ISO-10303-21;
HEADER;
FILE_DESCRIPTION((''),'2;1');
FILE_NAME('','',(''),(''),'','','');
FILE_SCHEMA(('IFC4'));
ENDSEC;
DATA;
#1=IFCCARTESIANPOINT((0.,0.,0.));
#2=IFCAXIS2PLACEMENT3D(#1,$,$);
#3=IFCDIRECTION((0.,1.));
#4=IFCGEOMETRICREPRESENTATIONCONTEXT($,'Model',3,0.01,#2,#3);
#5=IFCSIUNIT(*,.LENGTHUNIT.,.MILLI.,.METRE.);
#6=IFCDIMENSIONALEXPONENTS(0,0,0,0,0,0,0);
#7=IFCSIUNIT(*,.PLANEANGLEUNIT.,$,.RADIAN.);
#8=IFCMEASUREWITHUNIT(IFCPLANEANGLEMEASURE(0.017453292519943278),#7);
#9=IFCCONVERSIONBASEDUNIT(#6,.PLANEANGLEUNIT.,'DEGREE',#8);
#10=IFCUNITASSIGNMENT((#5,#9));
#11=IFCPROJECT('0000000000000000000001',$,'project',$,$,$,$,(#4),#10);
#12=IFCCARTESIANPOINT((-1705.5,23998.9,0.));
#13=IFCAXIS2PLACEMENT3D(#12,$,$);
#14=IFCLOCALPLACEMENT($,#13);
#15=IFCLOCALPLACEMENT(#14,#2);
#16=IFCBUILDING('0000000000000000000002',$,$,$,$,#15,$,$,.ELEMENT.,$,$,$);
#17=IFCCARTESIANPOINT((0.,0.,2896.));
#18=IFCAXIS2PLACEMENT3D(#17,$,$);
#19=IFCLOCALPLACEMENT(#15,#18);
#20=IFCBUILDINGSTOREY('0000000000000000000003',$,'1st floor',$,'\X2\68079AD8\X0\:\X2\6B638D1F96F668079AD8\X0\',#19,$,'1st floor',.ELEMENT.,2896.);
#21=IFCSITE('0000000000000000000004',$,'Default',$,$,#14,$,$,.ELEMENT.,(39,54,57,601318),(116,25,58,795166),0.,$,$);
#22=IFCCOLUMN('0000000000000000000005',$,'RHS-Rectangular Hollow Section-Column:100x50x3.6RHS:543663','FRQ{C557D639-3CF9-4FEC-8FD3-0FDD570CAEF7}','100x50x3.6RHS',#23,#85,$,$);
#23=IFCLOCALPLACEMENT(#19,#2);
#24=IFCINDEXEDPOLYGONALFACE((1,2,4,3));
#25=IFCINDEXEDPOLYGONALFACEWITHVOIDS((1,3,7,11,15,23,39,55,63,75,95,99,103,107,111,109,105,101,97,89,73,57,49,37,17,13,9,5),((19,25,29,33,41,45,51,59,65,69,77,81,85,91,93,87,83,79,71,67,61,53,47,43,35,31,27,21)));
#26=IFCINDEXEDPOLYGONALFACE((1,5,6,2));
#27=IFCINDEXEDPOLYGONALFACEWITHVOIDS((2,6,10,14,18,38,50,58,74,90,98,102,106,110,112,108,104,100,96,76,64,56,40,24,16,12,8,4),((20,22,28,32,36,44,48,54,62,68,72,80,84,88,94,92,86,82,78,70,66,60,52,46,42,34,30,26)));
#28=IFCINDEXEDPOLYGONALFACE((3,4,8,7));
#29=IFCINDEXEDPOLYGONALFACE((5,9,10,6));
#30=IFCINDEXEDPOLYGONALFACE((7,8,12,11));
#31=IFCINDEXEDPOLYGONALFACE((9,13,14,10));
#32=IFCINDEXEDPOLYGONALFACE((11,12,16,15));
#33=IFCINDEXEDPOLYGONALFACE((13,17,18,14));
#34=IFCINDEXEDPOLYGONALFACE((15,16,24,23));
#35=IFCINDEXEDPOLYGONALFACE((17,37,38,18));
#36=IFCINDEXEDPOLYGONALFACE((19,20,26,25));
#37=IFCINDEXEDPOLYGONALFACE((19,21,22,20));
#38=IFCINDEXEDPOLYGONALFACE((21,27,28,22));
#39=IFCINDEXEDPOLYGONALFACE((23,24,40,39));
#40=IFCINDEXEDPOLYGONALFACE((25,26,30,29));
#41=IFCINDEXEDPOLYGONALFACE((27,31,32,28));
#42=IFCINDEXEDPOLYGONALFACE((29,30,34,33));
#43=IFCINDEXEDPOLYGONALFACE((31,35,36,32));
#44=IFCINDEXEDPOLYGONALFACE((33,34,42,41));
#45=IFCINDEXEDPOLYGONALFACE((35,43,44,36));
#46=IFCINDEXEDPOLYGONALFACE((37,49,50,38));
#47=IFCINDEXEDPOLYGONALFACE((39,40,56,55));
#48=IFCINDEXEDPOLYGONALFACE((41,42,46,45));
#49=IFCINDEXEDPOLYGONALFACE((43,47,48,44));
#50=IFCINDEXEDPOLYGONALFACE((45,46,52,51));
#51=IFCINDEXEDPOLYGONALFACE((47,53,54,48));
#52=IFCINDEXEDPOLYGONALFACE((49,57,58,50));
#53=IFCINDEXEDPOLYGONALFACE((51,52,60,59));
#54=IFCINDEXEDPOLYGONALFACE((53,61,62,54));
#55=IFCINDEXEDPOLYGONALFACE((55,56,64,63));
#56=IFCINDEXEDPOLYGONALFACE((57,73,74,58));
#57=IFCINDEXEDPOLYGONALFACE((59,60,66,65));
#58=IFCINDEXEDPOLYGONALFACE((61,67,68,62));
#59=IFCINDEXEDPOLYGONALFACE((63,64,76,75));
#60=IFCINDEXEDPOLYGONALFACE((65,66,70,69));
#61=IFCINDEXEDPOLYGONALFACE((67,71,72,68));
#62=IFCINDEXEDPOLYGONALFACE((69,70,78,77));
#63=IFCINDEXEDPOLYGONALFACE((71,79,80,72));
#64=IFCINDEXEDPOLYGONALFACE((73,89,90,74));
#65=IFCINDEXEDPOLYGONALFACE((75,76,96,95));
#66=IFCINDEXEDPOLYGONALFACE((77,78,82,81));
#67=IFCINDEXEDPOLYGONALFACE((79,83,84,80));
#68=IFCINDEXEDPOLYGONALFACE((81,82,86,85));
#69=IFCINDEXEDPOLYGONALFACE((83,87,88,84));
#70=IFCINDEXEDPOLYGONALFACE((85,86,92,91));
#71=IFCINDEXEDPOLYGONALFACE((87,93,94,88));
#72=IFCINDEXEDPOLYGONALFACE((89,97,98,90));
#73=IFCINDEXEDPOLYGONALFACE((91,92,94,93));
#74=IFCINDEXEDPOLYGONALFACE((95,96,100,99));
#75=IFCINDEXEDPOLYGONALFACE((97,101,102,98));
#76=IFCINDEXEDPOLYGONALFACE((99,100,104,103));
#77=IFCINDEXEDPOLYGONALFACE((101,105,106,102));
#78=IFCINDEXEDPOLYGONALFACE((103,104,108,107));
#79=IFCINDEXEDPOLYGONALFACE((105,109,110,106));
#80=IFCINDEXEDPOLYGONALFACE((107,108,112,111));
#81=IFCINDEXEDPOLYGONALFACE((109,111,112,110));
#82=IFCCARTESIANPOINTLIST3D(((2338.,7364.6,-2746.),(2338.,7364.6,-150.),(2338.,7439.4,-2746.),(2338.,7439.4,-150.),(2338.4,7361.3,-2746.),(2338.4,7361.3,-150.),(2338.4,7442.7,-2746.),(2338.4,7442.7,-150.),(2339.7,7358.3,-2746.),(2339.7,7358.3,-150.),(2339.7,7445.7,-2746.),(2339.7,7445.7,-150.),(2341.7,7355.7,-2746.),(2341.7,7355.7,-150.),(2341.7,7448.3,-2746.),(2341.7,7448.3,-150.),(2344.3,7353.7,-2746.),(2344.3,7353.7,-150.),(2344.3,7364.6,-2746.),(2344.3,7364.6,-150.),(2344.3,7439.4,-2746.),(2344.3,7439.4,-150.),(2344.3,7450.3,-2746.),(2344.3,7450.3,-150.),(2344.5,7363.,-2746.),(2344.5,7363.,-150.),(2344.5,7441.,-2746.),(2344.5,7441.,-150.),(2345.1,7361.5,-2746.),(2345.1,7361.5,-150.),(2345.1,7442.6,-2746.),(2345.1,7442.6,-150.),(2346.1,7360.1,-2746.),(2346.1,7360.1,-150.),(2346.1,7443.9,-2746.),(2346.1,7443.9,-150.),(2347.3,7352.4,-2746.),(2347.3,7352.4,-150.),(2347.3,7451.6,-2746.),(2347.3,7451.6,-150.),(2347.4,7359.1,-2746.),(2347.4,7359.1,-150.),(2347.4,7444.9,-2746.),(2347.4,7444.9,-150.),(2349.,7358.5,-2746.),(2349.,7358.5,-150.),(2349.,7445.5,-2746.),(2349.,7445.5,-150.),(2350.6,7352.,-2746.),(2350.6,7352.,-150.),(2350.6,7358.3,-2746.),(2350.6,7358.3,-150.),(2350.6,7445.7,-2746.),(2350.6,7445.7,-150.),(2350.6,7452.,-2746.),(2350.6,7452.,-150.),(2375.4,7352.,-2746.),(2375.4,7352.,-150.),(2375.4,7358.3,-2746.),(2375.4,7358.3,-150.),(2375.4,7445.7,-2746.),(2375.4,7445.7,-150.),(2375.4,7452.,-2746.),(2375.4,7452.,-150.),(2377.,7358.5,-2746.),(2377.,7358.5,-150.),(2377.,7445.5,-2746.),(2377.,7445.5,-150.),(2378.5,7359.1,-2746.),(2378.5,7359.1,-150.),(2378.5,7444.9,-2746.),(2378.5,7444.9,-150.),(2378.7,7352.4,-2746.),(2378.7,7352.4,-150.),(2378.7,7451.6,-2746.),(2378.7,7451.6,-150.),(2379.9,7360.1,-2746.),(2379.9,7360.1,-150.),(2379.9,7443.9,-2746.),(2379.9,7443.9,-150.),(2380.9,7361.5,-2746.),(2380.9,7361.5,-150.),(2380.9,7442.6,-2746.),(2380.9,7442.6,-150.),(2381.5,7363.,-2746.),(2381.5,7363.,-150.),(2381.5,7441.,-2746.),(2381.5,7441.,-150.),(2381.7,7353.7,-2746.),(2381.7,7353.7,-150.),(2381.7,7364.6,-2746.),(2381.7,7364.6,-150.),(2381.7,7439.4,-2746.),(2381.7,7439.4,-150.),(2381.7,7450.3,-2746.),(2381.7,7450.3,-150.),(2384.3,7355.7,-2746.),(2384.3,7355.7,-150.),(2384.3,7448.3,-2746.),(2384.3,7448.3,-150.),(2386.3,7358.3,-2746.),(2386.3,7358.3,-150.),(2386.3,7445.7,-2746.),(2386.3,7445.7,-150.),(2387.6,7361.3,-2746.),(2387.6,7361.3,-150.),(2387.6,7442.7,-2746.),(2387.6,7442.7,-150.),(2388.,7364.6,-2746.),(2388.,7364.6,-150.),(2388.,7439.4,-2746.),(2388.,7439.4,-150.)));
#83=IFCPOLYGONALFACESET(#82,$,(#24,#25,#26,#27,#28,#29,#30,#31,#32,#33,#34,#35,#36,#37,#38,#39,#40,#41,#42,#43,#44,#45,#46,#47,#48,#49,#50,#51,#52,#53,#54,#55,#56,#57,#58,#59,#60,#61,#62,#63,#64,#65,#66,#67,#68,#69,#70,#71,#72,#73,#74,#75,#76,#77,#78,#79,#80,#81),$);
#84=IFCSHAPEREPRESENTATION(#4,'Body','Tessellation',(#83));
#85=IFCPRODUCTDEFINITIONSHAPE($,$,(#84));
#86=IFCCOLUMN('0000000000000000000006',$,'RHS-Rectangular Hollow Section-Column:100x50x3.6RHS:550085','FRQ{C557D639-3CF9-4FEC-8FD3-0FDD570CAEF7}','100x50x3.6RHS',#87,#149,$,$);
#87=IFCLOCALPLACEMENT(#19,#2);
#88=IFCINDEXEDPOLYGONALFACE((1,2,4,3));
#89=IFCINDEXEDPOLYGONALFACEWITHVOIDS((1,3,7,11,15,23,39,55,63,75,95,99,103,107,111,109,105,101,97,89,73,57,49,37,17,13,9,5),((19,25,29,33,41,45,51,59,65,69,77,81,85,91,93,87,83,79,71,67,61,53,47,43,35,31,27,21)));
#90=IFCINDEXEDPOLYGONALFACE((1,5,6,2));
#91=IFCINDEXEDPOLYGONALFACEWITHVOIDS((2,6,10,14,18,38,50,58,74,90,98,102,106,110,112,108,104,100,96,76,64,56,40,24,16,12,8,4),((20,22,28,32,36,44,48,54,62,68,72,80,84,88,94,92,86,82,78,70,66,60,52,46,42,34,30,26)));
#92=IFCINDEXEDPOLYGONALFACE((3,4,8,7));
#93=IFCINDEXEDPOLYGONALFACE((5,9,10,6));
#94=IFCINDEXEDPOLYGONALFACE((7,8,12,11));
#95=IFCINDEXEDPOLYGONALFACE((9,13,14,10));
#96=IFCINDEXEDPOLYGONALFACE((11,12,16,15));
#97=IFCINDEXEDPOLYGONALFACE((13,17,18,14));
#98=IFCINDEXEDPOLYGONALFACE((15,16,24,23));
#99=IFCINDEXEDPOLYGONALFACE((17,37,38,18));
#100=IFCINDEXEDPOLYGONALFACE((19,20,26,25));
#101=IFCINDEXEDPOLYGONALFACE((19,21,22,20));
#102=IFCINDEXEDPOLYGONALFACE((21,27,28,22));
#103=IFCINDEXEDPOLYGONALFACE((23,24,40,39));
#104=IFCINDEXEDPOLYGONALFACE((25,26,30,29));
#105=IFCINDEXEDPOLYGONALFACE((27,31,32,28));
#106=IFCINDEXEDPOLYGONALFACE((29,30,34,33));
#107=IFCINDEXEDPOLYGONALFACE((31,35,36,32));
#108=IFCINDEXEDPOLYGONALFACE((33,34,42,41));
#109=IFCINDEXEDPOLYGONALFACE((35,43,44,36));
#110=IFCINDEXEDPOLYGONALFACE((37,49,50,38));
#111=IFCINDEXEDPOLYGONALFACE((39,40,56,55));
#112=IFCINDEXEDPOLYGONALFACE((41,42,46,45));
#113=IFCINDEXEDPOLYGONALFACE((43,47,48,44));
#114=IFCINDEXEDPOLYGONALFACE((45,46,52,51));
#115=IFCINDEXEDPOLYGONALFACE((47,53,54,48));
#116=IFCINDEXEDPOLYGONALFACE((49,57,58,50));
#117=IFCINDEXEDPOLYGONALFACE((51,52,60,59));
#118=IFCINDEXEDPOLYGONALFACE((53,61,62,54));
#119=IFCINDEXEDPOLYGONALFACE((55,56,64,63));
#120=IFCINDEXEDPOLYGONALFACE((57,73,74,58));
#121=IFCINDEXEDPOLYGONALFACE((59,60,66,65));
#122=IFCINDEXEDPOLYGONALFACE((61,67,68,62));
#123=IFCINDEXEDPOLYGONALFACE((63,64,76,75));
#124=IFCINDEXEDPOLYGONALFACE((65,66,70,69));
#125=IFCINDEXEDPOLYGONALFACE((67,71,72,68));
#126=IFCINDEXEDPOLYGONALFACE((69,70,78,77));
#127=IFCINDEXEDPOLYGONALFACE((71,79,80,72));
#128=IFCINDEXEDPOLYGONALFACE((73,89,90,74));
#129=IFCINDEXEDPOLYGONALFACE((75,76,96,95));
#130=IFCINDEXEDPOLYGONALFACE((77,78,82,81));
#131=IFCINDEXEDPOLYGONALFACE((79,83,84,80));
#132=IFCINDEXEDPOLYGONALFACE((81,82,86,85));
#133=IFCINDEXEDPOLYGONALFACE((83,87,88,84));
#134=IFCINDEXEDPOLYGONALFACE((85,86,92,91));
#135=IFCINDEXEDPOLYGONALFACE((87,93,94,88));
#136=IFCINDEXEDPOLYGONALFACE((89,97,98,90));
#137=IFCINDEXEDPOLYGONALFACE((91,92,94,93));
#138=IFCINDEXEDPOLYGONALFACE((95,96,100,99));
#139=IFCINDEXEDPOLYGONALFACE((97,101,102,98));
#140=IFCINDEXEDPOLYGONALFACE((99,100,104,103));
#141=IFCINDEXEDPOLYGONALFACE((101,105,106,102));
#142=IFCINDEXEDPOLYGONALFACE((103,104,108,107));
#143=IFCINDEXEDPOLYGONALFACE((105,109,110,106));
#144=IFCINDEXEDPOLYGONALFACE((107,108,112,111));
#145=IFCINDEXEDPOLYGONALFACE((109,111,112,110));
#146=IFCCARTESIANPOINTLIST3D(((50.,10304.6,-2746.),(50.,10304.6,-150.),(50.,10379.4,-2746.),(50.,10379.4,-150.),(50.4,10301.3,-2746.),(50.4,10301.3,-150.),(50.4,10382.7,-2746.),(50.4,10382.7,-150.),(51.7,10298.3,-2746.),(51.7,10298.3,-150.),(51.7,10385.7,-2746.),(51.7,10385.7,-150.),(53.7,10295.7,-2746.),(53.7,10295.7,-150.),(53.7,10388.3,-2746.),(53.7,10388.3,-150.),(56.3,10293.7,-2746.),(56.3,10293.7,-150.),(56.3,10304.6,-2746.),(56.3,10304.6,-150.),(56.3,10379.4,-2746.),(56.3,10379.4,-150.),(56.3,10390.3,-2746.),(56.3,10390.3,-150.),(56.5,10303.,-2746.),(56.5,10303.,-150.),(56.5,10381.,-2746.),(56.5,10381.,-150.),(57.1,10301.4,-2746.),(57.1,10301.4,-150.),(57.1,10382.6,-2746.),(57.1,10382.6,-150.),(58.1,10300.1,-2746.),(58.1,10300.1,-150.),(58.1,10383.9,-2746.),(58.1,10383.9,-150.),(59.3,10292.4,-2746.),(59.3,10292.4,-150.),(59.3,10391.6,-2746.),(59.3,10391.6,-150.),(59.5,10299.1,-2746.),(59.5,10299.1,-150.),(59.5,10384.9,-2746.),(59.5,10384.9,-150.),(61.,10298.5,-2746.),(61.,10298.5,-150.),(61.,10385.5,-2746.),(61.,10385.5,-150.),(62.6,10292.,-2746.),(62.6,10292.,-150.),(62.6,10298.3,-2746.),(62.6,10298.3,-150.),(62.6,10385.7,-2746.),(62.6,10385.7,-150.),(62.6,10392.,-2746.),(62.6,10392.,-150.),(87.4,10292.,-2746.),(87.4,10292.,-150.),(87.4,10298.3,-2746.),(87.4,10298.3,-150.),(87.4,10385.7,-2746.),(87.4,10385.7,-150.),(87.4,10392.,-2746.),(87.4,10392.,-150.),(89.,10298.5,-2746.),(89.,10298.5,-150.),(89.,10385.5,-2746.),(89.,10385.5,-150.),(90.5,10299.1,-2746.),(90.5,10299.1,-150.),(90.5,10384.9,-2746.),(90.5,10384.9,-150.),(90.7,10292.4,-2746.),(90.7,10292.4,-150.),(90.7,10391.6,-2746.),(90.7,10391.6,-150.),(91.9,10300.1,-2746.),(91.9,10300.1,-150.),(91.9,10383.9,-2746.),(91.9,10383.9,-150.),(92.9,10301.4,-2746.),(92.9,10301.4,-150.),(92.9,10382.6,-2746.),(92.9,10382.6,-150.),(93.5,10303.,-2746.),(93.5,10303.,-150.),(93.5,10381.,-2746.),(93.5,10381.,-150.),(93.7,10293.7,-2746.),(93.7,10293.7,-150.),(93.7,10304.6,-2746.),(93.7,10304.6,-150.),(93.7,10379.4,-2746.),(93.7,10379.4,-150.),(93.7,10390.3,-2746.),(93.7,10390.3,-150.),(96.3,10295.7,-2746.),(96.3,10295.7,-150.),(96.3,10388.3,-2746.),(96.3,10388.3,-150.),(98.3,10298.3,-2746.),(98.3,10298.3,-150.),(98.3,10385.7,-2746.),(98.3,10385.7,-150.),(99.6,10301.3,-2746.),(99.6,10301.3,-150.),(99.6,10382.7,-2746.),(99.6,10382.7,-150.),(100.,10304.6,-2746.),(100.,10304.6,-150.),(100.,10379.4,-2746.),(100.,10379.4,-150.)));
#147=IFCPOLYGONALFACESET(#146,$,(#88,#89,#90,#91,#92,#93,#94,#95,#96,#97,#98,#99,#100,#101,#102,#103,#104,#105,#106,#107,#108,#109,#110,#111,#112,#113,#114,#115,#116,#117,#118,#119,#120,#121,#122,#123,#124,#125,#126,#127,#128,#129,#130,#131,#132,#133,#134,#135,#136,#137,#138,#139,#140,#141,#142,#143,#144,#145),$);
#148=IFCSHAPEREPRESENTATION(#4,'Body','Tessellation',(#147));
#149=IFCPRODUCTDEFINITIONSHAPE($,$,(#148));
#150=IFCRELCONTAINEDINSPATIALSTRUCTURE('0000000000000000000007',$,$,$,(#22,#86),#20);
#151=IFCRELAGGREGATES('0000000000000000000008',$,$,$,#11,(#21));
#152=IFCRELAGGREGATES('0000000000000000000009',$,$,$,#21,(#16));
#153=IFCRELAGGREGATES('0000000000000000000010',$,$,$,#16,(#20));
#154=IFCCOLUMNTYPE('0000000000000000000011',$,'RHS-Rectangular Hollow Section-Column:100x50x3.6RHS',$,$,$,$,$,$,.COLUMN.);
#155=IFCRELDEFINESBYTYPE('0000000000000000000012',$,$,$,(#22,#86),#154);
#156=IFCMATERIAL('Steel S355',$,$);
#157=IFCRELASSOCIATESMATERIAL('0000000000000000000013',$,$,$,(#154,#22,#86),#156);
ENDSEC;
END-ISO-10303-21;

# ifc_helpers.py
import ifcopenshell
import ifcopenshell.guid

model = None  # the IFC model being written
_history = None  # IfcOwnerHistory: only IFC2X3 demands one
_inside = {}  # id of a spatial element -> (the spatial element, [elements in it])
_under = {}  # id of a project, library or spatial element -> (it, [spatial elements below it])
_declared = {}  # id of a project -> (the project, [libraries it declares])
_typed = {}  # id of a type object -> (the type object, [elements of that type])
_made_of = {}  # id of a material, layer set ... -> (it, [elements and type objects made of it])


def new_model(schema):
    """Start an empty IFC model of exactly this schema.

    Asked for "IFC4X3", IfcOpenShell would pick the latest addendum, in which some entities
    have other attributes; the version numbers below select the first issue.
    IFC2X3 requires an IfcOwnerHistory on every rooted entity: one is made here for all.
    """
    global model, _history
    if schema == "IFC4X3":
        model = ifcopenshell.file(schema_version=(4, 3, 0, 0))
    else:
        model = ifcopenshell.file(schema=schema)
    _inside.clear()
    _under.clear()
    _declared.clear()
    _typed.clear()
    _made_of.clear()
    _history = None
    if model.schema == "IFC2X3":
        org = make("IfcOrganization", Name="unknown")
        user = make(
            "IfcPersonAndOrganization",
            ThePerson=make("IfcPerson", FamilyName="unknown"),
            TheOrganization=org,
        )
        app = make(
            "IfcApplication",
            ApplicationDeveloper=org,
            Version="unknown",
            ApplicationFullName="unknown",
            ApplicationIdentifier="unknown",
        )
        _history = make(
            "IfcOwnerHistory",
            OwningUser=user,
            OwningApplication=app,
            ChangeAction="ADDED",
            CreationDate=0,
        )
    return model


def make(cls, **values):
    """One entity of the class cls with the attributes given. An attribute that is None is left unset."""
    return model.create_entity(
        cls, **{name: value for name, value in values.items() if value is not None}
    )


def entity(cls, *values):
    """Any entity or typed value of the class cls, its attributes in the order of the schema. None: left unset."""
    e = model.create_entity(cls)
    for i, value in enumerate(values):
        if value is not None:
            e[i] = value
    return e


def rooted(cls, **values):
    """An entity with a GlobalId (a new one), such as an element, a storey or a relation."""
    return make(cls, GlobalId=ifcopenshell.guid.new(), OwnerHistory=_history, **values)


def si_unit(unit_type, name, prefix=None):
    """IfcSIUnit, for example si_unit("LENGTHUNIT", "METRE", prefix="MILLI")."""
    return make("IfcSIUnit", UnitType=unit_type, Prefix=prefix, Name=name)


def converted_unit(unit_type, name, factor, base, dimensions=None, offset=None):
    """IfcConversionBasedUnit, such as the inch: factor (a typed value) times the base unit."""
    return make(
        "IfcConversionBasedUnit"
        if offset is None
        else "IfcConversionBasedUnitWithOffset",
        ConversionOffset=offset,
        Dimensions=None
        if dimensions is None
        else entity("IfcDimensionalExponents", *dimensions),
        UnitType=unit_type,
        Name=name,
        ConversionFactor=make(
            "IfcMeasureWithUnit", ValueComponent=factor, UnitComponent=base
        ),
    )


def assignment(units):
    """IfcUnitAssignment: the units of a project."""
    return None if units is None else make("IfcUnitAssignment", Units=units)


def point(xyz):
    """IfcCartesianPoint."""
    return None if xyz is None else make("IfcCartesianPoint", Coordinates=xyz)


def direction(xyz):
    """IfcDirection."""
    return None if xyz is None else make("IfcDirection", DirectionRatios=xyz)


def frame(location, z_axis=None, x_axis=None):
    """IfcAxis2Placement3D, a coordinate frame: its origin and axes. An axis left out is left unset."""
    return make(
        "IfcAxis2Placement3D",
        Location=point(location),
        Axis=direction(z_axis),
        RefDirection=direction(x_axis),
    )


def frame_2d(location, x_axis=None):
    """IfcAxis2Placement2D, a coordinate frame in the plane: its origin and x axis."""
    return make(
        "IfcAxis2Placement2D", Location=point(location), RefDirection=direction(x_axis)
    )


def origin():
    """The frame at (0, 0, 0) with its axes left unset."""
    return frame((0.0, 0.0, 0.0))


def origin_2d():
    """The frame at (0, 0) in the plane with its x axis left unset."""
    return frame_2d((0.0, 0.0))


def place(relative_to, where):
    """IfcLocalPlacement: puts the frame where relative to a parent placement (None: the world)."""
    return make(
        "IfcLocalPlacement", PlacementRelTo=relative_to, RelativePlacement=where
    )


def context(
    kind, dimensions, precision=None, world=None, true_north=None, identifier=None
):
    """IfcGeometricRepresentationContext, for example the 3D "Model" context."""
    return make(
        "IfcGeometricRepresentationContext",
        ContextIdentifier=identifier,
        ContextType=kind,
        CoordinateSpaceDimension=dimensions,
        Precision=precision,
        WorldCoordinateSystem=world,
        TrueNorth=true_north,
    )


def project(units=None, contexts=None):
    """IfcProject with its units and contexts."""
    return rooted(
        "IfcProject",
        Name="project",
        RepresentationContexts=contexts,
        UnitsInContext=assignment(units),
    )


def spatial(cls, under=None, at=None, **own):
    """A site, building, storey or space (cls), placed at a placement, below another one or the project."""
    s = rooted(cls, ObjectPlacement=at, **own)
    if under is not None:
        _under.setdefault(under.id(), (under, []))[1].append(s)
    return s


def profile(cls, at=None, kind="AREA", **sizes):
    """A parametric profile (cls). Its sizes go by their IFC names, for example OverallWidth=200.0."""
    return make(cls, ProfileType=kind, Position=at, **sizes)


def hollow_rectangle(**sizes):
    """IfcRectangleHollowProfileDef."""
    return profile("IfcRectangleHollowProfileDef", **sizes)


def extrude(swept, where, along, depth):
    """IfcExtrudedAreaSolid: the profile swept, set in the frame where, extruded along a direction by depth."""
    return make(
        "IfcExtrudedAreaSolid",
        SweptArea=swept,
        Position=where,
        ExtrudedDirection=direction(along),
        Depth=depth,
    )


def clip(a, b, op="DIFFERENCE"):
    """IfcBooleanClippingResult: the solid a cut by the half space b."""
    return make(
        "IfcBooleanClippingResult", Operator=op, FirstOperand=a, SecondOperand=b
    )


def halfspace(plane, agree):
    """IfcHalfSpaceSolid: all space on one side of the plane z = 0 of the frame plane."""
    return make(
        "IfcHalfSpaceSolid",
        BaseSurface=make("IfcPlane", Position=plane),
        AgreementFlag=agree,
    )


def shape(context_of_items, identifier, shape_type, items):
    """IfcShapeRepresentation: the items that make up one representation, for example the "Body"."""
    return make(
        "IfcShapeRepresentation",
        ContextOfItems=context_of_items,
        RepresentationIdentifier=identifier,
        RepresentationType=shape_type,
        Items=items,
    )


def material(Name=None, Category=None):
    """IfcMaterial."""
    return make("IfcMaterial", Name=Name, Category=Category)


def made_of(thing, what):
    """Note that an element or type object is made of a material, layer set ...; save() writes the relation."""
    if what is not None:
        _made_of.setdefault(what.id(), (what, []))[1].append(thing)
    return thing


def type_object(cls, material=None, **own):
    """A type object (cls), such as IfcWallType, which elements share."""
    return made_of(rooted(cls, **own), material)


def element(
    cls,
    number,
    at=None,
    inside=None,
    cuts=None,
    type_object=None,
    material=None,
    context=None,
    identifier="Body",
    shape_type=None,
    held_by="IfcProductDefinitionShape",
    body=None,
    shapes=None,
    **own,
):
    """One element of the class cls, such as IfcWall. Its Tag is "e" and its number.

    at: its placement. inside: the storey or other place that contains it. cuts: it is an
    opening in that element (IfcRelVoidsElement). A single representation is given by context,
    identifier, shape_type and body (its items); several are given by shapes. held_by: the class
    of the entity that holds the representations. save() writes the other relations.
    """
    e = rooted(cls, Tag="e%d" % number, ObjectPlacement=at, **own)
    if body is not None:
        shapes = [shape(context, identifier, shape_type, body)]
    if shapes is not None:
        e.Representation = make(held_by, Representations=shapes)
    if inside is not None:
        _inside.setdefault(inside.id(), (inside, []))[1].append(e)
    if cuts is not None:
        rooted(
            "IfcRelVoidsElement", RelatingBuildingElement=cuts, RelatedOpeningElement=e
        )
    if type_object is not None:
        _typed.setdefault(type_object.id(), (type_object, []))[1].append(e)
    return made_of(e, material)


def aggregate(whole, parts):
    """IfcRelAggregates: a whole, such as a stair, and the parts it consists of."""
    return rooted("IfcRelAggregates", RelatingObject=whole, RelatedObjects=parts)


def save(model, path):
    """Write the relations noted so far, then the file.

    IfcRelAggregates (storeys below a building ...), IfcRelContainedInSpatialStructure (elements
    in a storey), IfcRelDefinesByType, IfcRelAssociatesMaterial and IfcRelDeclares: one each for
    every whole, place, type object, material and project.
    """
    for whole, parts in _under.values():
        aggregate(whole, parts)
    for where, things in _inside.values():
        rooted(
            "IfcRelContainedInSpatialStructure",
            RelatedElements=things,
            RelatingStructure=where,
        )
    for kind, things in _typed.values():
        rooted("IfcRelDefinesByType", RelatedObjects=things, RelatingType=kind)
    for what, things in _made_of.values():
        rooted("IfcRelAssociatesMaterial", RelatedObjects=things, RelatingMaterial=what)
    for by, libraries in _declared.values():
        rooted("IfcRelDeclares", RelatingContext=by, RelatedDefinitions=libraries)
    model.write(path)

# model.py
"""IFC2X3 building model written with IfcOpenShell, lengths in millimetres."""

from ifc_helpers import new_model, entity, si_unit, converted_unit, direction, frame, origin, origin_2d, place, context, project, spatial, hollow_rectangle, extrude, clip, halfspace, material, type_object, element, save


model = new_model("IFC2X3")

# Units and contexts
model_context = context("Model", 3, precision=0.01, world=origin(), true_north=direction((0.0, 1.0)))
ifc_project = project(units=[si_unit("LENGTHUNIT", "METRE", prefix="MILLI"), converted_unit("PLANEANGLEUNIT", "DEGREE", entity("IfcPlaneAngleMeasure", 0.017453292519943278), si_unit("PLANEANGLEUNIT", "RADIAN"), dimensions=[0, 0, 0, 0, 0, 0, 0])], contexts=[model_context])

# Site, building, storey
site_placement = place(None, frame((-1705.5, 23998.9, 0.0)))
site = spatial("IfcSite", under=ifc_project, at=site_placement, Name="Default", CompositionType="ELEMENT", RefLatitude=(39, 54, 57, 601318), RefLongitude=(116, 25, 58, 795166), RefElevation=0.0)
building_placement = place(site_placement, origin())
building = spatial("IfcBuilding", under=site, at=building_placement, CompositionType="ELEMENT")
storey_placement = place(building_placement, frame((0.0, 0.0, 2896.0)))
storey = spatial("IfcBuildingStorey", under=building, at=storey_placement, Name="1st floor", ObjectType="标高:正负零标高", LongName="1st floor", CompositionType="ELEMENT", Elevation=2896.0)

# Columns
ifc_material_1 = material(Name="Steel S355")
column_type = type_object("IfcColumnType", Name="RHS-Rectangular Hollow Section-Column:100x50x3.6RHS", PredefinedType="COLUMN", material=ifc_material_1)
column_1_placement = place(storey_placement, frame((2363.0, 7402.0, -150.0), z_axis=(0.0, 0.0, 1.0), x_axis=(-1.0, 0.0, 0.0)))
element("IfcColumn", 1, at=column_1_placement, inside=storey, type_object=column_type, material=ifc_material_1, Name="RHS-Rectangular Hollow Section-Column:100x50x3.6RHS:543663", Description="FRQ{C557D639-3CF9-4FEC-8FD3-0FDD570CAEF7}", ObjectType="100x50x3.6RHS", context=model_context, shape_type="Clipping", body=[
    clip(extrude(hollow_rectangle(XDim=50.0, YDim=100.0, WallThickness=6.3, InnerFilletRadius=6.3, OuterFilletRadius=12.6, at=origin_2d()), origin(), (0.0, 0.0, -1.0), 2651.9), halfspace(frame((2363.0, 7402.0, -2596.0), z_axis=(0.0, 0.0, 1.0), x_axis=(-1.0, 0.0, 0.0)), True)),
])
column_2_placement = place(storey_placement, frame((75.0, 10342.0, -150.0), z_axis=(0.0, 0.0, 1.0), x_axis=(-1.0, 0.0, 0.0)))
element("IfcColumn", 2, at=column_2_placement, inside=storey, type_object=column_type, material=ifc_material_1, Name="RHS-Rectangular Hollow Section-Column:100x50x3.6RHS:550085", Description="FRQ{C557D639-3CF9-4FEC-8FD3-0FDD570CAEF7}", ObjectType="100x50x3.6RHS", context=model_context, shape_type="Clipping", body=[
    clip(extrude(hollow_rectangle(XDim=50.0, YDim=100.0, WallThickness=6.3, InnerFilletRadius=6.3, OuterFilletRadius=12.6, at=origin_2d()), origin(), (0.0, 0.0, -1.0), 2651.9), halfspace(frame((75.0, 10342.0, -2596.0), z_axis=(0.0, 0.0, 1.0), x_axis=(-1.0, 0.0, 0.0)), True)),
])

save(model, "model.ifc")
